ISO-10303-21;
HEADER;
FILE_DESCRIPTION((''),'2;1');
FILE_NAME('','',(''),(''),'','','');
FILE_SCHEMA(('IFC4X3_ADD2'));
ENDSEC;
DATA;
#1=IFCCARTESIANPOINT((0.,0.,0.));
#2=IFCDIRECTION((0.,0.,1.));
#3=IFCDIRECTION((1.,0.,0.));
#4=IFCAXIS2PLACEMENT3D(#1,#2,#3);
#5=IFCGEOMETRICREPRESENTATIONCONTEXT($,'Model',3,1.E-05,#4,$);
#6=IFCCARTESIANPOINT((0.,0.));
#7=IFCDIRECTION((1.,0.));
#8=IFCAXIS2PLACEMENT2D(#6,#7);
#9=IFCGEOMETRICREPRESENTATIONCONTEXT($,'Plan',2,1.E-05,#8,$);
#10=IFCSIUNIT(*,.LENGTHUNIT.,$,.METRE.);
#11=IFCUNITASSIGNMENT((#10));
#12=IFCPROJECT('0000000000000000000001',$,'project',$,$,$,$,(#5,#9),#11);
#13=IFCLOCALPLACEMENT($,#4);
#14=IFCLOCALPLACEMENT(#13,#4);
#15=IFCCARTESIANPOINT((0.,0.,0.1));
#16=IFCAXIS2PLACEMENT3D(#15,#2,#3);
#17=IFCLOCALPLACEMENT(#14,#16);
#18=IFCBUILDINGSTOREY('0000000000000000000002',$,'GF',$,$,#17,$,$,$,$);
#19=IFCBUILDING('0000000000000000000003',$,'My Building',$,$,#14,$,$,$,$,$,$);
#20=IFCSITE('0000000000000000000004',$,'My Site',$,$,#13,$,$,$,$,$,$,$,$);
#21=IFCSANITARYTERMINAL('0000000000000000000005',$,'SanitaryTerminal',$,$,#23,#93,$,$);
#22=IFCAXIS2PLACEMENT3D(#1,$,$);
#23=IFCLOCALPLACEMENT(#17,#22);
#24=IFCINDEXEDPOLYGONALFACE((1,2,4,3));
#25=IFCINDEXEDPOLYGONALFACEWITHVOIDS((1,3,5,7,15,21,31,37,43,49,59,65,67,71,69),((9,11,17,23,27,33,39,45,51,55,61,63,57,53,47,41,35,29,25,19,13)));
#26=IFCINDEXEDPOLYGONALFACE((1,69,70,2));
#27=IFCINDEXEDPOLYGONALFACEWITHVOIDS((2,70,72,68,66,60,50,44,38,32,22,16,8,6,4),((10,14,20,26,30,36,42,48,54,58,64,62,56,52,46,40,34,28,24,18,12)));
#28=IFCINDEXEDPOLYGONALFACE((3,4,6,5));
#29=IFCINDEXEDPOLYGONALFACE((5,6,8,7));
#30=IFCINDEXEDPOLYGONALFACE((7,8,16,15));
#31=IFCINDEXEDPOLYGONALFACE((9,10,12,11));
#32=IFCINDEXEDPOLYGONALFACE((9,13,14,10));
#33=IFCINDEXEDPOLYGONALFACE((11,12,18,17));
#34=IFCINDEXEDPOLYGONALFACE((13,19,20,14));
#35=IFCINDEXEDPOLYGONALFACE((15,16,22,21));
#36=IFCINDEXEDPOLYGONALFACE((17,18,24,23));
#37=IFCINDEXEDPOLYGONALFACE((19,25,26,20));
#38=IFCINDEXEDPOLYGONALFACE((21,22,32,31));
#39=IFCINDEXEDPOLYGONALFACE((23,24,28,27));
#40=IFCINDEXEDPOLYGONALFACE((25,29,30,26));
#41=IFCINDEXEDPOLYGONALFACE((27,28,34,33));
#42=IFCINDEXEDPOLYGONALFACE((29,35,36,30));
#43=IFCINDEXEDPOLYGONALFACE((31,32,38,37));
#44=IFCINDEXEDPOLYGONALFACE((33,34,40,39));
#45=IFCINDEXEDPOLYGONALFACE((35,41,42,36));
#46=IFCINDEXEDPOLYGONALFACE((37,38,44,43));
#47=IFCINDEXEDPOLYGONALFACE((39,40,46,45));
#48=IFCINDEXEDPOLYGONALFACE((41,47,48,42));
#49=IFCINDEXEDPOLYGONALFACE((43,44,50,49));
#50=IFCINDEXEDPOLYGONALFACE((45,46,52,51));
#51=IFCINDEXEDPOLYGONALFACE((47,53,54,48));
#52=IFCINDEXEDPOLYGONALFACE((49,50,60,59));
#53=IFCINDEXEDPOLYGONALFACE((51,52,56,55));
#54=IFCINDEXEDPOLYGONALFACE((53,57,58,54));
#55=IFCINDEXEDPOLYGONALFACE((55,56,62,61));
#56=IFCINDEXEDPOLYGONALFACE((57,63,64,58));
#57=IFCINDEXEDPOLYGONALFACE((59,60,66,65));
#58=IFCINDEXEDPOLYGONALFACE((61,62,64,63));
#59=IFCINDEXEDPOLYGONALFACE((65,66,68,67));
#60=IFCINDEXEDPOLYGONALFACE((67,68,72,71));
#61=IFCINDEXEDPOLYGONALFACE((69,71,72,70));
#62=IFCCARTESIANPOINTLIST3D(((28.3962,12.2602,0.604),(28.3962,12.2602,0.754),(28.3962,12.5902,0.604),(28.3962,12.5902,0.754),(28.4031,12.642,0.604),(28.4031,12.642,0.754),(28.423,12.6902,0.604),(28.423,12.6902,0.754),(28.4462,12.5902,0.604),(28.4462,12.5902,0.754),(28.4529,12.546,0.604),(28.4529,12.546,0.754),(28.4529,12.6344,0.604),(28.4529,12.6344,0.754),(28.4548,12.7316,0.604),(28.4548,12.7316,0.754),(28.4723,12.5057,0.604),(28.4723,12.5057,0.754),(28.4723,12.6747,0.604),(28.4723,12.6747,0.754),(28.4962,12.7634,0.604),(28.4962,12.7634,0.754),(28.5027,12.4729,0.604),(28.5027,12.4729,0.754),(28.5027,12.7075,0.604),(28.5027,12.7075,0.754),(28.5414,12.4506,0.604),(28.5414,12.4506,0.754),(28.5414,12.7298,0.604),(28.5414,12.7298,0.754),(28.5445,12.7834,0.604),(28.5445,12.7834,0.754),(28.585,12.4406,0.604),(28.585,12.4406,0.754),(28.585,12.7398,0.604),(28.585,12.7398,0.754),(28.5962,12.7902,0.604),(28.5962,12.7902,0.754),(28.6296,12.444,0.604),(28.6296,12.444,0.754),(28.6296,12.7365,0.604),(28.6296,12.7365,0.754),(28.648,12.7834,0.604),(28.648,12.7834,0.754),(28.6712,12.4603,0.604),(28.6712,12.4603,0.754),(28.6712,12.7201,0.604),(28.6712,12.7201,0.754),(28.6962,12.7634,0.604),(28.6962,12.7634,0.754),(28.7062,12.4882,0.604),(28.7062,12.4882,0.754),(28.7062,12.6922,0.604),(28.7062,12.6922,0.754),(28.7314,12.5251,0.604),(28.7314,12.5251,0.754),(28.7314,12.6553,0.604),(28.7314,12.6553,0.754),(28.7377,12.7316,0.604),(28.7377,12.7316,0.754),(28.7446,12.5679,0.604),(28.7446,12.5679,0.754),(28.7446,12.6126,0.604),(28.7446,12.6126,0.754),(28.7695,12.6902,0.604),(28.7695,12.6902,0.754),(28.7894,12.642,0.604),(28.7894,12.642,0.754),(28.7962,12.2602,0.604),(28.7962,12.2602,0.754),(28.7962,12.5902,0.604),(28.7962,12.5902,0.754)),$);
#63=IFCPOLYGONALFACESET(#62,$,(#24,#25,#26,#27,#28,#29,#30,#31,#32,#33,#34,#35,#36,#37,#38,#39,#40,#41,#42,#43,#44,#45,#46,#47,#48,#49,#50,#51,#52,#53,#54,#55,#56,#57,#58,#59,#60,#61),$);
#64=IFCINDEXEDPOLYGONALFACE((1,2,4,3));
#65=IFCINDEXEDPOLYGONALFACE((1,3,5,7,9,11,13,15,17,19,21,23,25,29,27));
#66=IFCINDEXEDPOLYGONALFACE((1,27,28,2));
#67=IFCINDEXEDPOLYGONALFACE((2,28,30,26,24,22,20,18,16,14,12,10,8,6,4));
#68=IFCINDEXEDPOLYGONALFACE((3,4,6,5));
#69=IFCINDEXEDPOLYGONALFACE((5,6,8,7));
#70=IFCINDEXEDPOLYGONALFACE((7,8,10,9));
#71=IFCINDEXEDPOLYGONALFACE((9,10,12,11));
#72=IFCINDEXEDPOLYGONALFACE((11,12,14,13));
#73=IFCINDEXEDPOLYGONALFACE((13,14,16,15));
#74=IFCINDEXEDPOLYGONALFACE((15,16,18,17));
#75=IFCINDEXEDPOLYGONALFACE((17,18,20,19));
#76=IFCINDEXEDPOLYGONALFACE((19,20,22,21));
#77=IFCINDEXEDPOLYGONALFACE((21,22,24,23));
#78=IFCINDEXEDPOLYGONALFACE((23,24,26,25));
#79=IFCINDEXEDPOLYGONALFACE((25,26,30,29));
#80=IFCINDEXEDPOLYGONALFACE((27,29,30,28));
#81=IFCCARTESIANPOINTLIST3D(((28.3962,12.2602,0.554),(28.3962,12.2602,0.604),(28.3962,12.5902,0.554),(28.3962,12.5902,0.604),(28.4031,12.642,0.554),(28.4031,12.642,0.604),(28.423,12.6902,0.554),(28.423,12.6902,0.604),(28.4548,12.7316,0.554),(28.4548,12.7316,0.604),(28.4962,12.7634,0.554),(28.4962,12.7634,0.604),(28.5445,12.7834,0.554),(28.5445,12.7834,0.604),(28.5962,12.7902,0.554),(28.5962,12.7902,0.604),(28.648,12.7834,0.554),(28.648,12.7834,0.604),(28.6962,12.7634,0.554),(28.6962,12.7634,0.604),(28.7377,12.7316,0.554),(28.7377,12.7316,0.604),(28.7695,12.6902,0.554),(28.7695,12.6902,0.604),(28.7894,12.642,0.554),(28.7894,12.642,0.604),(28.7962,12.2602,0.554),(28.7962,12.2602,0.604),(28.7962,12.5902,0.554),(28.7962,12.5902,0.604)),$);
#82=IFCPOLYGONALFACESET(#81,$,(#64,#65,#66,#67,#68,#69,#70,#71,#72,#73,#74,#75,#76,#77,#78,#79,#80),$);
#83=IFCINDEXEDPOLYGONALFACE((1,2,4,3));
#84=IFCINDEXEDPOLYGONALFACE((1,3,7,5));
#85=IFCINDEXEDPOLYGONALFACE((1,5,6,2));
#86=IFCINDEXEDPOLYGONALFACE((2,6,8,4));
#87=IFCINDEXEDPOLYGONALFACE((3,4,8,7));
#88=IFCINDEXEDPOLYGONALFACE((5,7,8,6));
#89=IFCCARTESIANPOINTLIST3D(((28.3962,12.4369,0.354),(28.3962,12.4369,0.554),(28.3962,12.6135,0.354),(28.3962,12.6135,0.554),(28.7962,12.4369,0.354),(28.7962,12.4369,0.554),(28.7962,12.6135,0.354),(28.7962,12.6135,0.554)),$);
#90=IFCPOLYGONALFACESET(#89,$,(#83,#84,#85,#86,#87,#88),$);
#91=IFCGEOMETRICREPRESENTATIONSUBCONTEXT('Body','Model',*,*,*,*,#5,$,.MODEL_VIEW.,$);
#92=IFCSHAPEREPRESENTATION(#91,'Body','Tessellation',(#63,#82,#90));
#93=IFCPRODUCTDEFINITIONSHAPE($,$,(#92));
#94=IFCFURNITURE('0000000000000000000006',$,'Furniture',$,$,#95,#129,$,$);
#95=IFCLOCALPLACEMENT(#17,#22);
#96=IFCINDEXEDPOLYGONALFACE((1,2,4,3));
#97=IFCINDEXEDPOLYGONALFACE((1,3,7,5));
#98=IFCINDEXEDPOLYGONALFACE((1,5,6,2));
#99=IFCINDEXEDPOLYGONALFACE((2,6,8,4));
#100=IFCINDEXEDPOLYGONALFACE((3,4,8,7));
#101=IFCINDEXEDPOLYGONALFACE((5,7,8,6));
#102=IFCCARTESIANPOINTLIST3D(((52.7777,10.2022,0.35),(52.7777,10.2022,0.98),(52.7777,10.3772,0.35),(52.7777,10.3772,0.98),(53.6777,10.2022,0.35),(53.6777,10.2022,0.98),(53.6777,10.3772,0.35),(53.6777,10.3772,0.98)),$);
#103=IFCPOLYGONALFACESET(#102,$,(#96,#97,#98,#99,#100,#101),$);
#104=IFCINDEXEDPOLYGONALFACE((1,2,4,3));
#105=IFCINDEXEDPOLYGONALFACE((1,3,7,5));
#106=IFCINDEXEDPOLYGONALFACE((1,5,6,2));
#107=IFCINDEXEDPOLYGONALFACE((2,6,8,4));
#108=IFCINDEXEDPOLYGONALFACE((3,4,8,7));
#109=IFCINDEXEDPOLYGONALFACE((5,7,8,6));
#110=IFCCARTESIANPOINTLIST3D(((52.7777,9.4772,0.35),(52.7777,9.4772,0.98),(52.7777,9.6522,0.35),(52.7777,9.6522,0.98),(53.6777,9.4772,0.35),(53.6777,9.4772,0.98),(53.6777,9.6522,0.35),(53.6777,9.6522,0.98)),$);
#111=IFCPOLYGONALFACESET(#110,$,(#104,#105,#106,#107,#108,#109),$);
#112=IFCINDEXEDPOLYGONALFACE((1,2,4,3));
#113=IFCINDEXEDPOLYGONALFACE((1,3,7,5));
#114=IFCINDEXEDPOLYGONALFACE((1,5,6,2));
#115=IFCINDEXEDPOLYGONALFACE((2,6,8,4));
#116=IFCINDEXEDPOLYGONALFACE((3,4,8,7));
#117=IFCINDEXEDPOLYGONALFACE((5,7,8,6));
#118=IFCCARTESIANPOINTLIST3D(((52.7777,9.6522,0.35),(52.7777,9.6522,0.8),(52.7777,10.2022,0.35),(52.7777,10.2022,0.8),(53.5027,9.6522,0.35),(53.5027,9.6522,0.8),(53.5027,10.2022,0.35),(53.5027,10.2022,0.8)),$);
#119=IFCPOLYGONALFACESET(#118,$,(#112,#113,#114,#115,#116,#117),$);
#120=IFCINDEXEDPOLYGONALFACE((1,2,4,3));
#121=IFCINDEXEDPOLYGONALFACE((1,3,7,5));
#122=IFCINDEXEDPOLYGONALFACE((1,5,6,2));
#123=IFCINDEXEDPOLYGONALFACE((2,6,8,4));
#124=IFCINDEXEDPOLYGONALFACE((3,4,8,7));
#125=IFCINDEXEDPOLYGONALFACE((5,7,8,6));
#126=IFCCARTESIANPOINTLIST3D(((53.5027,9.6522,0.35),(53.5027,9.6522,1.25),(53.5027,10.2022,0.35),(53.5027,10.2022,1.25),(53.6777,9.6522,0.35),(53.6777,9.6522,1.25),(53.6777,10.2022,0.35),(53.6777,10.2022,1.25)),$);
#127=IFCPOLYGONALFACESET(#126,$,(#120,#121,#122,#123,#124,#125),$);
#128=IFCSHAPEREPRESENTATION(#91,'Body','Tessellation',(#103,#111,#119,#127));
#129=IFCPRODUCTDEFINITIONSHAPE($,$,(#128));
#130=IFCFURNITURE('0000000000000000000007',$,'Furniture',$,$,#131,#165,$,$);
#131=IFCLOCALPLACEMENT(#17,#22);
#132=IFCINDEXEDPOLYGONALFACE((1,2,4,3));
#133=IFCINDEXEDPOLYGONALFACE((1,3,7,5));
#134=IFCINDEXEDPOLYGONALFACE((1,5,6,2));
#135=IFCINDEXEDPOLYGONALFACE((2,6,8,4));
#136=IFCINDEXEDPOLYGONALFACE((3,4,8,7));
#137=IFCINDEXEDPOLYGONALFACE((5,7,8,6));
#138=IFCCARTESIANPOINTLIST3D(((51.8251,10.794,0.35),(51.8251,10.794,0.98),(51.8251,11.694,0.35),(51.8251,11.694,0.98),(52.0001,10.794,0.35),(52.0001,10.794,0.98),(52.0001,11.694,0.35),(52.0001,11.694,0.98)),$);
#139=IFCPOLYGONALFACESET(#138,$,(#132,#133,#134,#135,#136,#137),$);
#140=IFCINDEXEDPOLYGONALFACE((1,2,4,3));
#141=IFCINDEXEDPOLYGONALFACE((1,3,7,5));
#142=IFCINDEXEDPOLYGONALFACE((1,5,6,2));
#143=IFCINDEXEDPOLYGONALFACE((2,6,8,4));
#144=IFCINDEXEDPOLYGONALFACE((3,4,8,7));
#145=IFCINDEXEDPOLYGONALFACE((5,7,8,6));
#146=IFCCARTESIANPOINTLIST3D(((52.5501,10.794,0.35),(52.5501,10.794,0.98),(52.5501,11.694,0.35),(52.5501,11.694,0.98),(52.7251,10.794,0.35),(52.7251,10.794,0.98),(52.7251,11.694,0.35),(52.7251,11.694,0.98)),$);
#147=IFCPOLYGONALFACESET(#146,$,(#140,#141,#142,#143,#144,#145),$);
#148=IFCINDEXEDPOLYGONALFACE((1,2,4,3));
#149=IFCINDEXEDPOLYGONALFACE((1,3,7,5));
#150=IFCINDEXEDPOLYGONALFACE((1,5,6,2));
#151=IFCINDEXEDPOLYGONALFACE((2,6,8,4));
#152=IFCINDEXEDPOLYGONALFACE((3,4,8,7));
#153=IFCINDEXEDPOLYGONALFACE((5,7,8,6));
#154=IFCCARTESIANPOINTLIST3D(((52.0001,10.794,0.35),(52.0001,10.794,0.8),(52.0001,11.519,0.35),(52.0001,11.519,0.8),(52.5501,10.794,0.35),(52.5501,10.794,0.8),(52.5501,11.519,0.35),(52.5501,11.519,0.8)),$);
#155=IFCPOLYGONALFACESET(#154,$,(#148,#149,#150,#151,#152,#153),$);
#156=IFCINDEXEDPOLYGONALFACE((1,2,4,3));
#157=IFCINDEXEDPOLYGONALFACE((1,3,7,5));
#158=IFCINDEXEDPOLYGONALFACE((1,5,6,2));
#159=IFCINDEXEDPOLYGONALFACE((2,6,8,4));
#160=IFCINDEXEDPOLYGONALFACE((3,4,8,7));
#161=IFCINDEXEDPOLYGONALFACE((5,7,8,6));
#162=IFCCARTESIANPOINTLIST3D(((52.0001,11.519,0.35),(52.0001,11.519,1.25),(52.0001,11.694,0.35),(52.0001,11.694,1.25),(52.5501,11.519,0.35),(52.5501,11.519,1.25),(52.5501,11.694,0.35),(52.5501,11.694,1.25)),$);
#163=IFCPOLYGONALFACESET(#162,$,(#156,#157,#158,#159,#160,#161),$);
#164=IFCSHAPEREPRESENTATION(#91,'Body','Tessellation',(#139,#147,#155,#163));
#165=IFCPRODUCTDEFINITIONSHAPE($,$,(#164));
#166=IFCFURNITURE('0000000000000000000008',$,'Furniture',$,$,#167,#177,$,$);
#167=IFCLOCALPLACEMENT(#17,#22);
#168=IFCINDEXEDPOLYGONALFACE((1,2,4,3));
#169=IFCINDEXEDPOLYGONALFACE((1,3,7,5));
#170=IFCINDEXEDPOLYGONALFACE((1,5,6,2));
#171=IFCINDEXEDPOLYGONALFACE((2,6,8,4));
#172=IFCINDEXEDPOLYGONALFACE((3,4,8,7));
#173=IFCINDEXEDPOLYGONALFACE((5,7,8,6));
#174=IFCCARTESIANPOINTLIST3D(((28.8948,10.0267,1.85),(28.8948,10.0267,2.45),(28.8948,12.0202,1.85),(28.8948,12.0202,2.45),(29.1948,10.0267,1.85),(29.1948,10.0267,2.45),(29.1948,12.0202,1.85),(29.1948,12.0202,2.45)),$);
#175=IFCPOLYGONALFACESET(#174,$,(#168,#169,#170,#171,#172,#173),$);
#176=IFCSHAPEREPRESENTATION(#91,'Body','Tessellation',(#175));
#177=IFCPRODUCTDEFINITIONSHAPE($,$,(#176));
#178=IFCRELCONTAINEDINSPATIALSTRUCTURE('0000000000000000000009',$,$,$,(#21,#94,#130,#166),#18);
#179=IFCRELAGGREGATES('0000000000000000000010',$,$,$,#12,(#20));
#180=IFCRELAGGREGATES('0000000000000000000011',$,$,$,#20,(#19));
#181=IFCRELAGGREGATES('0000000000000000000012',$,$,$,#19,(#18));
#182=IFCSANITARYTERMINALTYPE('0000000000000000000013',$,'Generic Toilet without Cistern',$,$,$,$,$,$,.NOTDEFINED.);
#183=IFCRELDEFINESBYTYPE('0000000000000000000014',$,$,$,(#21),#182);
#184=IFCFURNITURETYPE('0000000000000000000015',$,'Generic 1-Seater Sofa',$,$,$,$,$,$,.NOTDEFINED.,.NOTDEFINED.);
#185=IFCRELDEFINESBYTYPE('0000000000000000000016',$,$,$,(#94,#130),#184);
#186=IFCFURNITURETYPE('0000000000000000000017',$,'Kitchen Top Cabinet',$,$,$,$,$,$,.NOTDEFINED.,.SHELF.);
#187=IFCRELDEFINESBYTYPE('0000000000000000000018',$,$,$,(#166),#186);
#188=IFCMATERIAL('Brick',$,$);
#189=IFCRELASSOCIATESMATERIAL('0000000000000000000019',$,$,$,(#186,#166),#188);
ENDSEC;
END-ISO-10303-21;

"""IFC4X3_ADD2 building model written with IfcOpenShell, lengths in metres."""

from ifc_helpers import new_model, entity, si_unit, frame, frame_2d, origin_with_axes, origin_2d_with_axis, place, context, subcontext, project, spatial, line, arc, indexed_curve, circle_curve, rectangle, outline, extrude, shape, source, transform, mapped, material, material_profile, profile_set, profile_usage, type_object, type_shapes, element, save


model = new_model("IFC4X3_ADD2")

# Units and contexts
model_context = context("Model", 3, precision=1e-05, world=origin_with_axes())
plan_context = context("Plan", 2, precision=1e-05, world=origin_2d_with_axis())
body_context_1 = subcontext(model_context, "Body", "Model", "MODEL_VIEW")
body_context_2 = subcontext(plan_context, "Body", "Plan", "PLAN_VIEW")
ifc_project = project(units=[si_unit("LENGTHUNIT", "METRE")], contexts=[model_context, plan_context])

# Site, building, storey
site_placement = place(None, origin_with_axes())
site = spatial("IfcSite", under=ifc_project, at=site_placement, Name="My Site")
building_placement = place(site_placement, origin_with_axes())
building = spatial("IfcBuilding", under=site, at=building_placement, Name="My Building")
storey_placement = place(building_placement, frame((0.0, 0.0, 0.1), z_axis=(0.0, 0.0, 1.0), x_axis=(1.0, 0.0, 0.0)))
storey = spatial("IfcBuildingStorey", under=building, at=storey_placement, Name="GF")

# Shared definitions
ifc_material_1 = material(Name="Brick")

# Sanitary terminal
sanitary_terminal_type = type_object("IfcSanitaryTerminalType", Name="Generic Toilet without Cistern", PredefinedType="NOTDEFINED")
shared_shape_1 = source(origin_with_axes(), body_context_1, "Body", "SweptSolid", [
    extrude(outline(indexed_curve([(-0.2, 0.0), (0.2, 0.0), (0.2, -0.33), (0.1414, -0.4714), (0.0, -0.53), (-0.1414, -0.4714), (-0.2, -0.33)], segments=[line(1, 2), line(2, 3), arc(3, 4, 5), arc(5, 6, 7), line(7, 1)]), holes=[circle_curve(frame_2d((0.0, -0.33)), 0.15)]), frame((0.0, 0.0, 0.25), z_axis=(0.0, 0.0, 1.0), x_axis=(1.0, 0.0, 0.0)), (0.0, 0.0, 1.0), 0.15),
    extrude(outline(indexed_curve([(-0.2, 0.0), (0.2, 0.0), (0.2, -0.33), (0.1414, -0.4714), (0.0, -0.53), (-0.1414, -0.4714), (-0.2, -0.33)], segments=[line(1, 2), line(2, 3), arc(3, 4, 5), arc(5, 6, 7), line(7, 1)])), frame((0.0, 0.0, 0.2), z_axis=(0.0, 0.0, 1.0), x_axis=(1.0, 0.0, 0.0)), (0.0, 0.0, 1.0), 0.05),
    extrude(outline(indexed_curve([(-0.2, -0.1767), (0.2, -0.1767), (0.2, -0.3533), (-0.2, -0.3533)], segments=[line(1, 2, 3, 4, 1)])), origin_with_axes(), (0.0, 0.0, 1.0), 0.2),
])
shared_shape_2 = source(origin_with_axes(), body_context_2, "Body", "GeometricSet", [
    entity("IfcGeometricCurveSet", [entity("IfcIndexedPolyCurve", entity("IfcCartesianPointList2D", [[-0.1068, -0.124], [-0.0957, -0.1129], [-0.0804, -0.1088], [0.0804, -0.1088], [0.0957, -0.1129], [0.1068, -0.124], [0.1109, -0.1393], [0.1109, -0.3476], [0.1025, -0.3926], [0.0784, -0.4308], [0.0424, -0.4563], [0.0, -0.4652], [-0.0424, -0.4563], [-0.0784, -0.4308], [-0.1025, -0.3926], [-0.1109, -0.3476], [-0.1109, -0.1393]]), [entity("IfcLineIndex", [1, 2, 3, 4, 5, 6, 7, 8, 9, 10, 11, 12, 13, 14, 15, 16, 17, 1])]), entity("IfcIndexedPolyCurve", entity("IfcCartesianPointList2D", [[-0.1962, -0.2314], [-0.1848, -0.301], [-0.1764, -0.3339], [-0.1663, -0.3651], [-0.1546, -0.3944], [-0.1414, -0.4213], [-0.1269, -0.4458], [-0.1111, -0.4675], [-0.0943, -0.4862], [-0.0765, -0.5018], [-0.0581, -0.514], [-0.039, -0.5229], [-0.0196, -0.5282], [0.0, -0.53], [0.0196, -0.5282], [0.039, -0.5229], [0.0581, -0.514], [0.0765, -0.5018], [0.0943, -0.4862], [0.1111, -0.4675], [0.1269, -0.4458], [0.1414, -0.4213], [0.1546, -0.3944], [0.1663, -0.3651], [0.1764, -0.3339], [0.1848, -0.301], [0.1962, -0.2314], [0.2, -0.159], [0.1872, 0.0], [-0.1872, 0.0], [-0.2, -0.159]]), [entity("IfcLineIndex", [1, 2, 3, 4, 5, 6, 7, 8, 9, 10, 11, 12, 13, 14, 15, 16, 17, 18, 19, 20, 21, 22, 23, 24, 25, 26, 27, 28, 29, 30, 31, 1])])]),
])
type_shapes(sanitary_terminal_type, [shared_shape_1, shared_shape_2])
sanitary_terminal_placement = place(storey_placement, frame((28.5962, 12.2602, 0.354), z_axis=(0.0, 0.0, 1.0), x_axis=(-1.0, 0.0, 0.0)))
element("IfcSanitaryTerminal", 1, at=sanitary_terminal_placement, inside=storey, type_object=sanitary_terminal_type, Name="SanitaryTerminal", shapes=[
    shape(body_context_1, "Body", "MappedRepresentation", [mapped(shared_shape_1, transform((0.0, 0.0, 0.0), x_axis=(1.0, 0.0, 0.0), y_axis=(0.0, 1.0, 0.0), z_axis=(0.0, 0.0, 1.0), scale=1.0))]),
    shape(body_context_2, "Body", "MappedRepresentation", [mapped(shared_shape_2, transform((0.0, 0.0, 0.0), x_axis=(1.0, 0.0, 0.0), y_axis=(0.0, 1.0, 0.0), z_axis=(0.0, 0.0, 1.0), scale=1.0))]),
])

# Furniture
furniture_type_1 = type_object("IfcFurnitureType", Name="Generic 1-Seater Sofa", AssemblyPlace="NOTDEFINED", PredefinedType="NOTDEFINED")
shared_shape_3 = source(origin_with_axes(), body_context_1, "Body", "SweptSolid", [
    extrude(outline(indexed_curve([(0.0, 0.0), (0.175, 0.0), (0.175, 0.9), (0.0, 0.9)], segments=[line(4, 1), line(1, 2), line(2, 3), line(3, 4)], self_intersect=False)), frame((-0.45, -0.9, 0.0), z_axis=(0.0, 0.0, 1.0), x_axis=(1.0, 0.0, 0.0)), (0.0, 0.0, 1.0), 0.63),
    extrude(outline(indexed_curve([(0.0, 0.0), (0.175, 0.0), (0.175, 0.9), (0.0, 0.9)], segments=[line(1, 2, 3, 4, 1)])), frame((0.275, -0.9, 0.0), z_axis=(0.0, 0.0, 1.0), x_axis=(1.0, 0.0, 0.0)), (0.0, 0.0, 1.0), 0.63),
    extrude(outline(indexed_curve([(0.175, 0.0), (0.725, 0.0), (0.725, 0.725), (0.175, 0.725)], segments=[line(1, 2, 3, 4, 1)])), frame((-0.45, -0.9, 0.0), z_axis=(0.0, 0.0, 1.0), x_axis=(1.0, 0.0, 0.0)), (0.0, 0.0, 1.0), 0.45),
    extrude(outline(indexed_curve([(0.175, 0.725), (0.725, 0.725), (0.725, 0.9), (0.175, 0.9)], segments=[line(1, 2, 3, 4, 1)])), frame((-0.45, -0.9, 0.0), z_axis=(0.0, 0.0, 1.0), x_axis=(1.0, 0.0, 0.0)), (0.0, 0.0, 1.0), 0.9),
])
shared_shape_4 = source(origin_with_axes(), body_context_2, "Body", "Annotation2D", [
    entity("IfcGeometricCurveSet", [entity("IfcIndexedPolyCurve", entity("IfcCartesianPointList2D", [[0.275, -0.175], [0.275, -0.9], [0.45, -0.9], [0.45, 0.0], [0.275, 0.0], [0.275, -0.9], [-0.275, -0.9], [-0.275, 0.0], [-0.275, -0.175], [0.275, -0.175], [0.275, 0.0], [-0.275, 0.0], [-0.45, 0.0], [-0.45, -0.9], [-0.275, -0.9], [-0.275, -0.175]]))]),
])
type_shapes(furniture_type_1, [shared_shape_3, shared_shape_4])
for number, where, z_axis, x_axis, name in (
    (2, (53.6777, 9.9272, 0.35), (0.0, 0.0, 1.0), (0.0, -1.0, 0.0), "Furniture"),
    (3, (52.2751, 11.694, 0.35), (0.0, 0.0, 1.0), (1.0, 0.0, 0.0), "Furniture"),
):
    element("IfcFurniture", number, at=place(storey_placement, frame(where, z_axis=z_axis, x_axis=x_axis)), inside=storey, type_object=furniture_type_1, Name=name, shapes=[
        shape(body_context_1, "Body", "MappedRepresentation", [mapped(shared_shape_3, transform((0.0, 0.0, 0.0), x_axis=(1.0, 0.0, 0.0), y_axis=(0.0, 1.0, 0.0), z_axis=(0.0, 0.0, 1.0), scale=1.0))]),
        shape(body_context_2, "Body", "MappedRepresentation", [mapped(shared_shape_4, transform((0.0, 0.0, 0.0), x_axis=(1.0, 0.0, 0.0), y_axis=(0.0, 1.0, 0.0), z_axis=(0.0, 0.0, 1.0), scale=1.0))]),
    ])
ifc_material_profile_1 = material_profile(ifc_material_1, rectangle(XDim=0.3, YDim=0.6))
ifc_profile_set_1 = profile_set([ifc_material_profile_1], Name="blank")
ifc_profile_usage_1 = profile_usage(ifc_profile_set_1, cardinal=5)
furniture_type_2 = type_object("IfcFurnitureType", Name="Kitchen Top Cabinet", AssemblyPlace="NOTDEFINED", PredefinedType="SHELF", material=ifc_profile_set_1)
furniture_1_placement = place(storey_placement, frame((29.0448, 12.0202, 2.15), z_axis=(0.0, -1.0, 0.0), x_axis=(1.0, 0.0, 0.0)))
element("IfcFurniture", 4, at=furniture_1_placement, inside=storey, type_object=furniture_type_2, material=ifc_profile_usage_1, Name="Furniture", context=body_context_1, shape_type="SweptSolid", body=[
    extrude(rectangle(XDim=0.3, YDim=0.6), origin_with_axes(), (0.0, 0.0, 1.0), 1.9936),
])

save(model, "model.ifc")
